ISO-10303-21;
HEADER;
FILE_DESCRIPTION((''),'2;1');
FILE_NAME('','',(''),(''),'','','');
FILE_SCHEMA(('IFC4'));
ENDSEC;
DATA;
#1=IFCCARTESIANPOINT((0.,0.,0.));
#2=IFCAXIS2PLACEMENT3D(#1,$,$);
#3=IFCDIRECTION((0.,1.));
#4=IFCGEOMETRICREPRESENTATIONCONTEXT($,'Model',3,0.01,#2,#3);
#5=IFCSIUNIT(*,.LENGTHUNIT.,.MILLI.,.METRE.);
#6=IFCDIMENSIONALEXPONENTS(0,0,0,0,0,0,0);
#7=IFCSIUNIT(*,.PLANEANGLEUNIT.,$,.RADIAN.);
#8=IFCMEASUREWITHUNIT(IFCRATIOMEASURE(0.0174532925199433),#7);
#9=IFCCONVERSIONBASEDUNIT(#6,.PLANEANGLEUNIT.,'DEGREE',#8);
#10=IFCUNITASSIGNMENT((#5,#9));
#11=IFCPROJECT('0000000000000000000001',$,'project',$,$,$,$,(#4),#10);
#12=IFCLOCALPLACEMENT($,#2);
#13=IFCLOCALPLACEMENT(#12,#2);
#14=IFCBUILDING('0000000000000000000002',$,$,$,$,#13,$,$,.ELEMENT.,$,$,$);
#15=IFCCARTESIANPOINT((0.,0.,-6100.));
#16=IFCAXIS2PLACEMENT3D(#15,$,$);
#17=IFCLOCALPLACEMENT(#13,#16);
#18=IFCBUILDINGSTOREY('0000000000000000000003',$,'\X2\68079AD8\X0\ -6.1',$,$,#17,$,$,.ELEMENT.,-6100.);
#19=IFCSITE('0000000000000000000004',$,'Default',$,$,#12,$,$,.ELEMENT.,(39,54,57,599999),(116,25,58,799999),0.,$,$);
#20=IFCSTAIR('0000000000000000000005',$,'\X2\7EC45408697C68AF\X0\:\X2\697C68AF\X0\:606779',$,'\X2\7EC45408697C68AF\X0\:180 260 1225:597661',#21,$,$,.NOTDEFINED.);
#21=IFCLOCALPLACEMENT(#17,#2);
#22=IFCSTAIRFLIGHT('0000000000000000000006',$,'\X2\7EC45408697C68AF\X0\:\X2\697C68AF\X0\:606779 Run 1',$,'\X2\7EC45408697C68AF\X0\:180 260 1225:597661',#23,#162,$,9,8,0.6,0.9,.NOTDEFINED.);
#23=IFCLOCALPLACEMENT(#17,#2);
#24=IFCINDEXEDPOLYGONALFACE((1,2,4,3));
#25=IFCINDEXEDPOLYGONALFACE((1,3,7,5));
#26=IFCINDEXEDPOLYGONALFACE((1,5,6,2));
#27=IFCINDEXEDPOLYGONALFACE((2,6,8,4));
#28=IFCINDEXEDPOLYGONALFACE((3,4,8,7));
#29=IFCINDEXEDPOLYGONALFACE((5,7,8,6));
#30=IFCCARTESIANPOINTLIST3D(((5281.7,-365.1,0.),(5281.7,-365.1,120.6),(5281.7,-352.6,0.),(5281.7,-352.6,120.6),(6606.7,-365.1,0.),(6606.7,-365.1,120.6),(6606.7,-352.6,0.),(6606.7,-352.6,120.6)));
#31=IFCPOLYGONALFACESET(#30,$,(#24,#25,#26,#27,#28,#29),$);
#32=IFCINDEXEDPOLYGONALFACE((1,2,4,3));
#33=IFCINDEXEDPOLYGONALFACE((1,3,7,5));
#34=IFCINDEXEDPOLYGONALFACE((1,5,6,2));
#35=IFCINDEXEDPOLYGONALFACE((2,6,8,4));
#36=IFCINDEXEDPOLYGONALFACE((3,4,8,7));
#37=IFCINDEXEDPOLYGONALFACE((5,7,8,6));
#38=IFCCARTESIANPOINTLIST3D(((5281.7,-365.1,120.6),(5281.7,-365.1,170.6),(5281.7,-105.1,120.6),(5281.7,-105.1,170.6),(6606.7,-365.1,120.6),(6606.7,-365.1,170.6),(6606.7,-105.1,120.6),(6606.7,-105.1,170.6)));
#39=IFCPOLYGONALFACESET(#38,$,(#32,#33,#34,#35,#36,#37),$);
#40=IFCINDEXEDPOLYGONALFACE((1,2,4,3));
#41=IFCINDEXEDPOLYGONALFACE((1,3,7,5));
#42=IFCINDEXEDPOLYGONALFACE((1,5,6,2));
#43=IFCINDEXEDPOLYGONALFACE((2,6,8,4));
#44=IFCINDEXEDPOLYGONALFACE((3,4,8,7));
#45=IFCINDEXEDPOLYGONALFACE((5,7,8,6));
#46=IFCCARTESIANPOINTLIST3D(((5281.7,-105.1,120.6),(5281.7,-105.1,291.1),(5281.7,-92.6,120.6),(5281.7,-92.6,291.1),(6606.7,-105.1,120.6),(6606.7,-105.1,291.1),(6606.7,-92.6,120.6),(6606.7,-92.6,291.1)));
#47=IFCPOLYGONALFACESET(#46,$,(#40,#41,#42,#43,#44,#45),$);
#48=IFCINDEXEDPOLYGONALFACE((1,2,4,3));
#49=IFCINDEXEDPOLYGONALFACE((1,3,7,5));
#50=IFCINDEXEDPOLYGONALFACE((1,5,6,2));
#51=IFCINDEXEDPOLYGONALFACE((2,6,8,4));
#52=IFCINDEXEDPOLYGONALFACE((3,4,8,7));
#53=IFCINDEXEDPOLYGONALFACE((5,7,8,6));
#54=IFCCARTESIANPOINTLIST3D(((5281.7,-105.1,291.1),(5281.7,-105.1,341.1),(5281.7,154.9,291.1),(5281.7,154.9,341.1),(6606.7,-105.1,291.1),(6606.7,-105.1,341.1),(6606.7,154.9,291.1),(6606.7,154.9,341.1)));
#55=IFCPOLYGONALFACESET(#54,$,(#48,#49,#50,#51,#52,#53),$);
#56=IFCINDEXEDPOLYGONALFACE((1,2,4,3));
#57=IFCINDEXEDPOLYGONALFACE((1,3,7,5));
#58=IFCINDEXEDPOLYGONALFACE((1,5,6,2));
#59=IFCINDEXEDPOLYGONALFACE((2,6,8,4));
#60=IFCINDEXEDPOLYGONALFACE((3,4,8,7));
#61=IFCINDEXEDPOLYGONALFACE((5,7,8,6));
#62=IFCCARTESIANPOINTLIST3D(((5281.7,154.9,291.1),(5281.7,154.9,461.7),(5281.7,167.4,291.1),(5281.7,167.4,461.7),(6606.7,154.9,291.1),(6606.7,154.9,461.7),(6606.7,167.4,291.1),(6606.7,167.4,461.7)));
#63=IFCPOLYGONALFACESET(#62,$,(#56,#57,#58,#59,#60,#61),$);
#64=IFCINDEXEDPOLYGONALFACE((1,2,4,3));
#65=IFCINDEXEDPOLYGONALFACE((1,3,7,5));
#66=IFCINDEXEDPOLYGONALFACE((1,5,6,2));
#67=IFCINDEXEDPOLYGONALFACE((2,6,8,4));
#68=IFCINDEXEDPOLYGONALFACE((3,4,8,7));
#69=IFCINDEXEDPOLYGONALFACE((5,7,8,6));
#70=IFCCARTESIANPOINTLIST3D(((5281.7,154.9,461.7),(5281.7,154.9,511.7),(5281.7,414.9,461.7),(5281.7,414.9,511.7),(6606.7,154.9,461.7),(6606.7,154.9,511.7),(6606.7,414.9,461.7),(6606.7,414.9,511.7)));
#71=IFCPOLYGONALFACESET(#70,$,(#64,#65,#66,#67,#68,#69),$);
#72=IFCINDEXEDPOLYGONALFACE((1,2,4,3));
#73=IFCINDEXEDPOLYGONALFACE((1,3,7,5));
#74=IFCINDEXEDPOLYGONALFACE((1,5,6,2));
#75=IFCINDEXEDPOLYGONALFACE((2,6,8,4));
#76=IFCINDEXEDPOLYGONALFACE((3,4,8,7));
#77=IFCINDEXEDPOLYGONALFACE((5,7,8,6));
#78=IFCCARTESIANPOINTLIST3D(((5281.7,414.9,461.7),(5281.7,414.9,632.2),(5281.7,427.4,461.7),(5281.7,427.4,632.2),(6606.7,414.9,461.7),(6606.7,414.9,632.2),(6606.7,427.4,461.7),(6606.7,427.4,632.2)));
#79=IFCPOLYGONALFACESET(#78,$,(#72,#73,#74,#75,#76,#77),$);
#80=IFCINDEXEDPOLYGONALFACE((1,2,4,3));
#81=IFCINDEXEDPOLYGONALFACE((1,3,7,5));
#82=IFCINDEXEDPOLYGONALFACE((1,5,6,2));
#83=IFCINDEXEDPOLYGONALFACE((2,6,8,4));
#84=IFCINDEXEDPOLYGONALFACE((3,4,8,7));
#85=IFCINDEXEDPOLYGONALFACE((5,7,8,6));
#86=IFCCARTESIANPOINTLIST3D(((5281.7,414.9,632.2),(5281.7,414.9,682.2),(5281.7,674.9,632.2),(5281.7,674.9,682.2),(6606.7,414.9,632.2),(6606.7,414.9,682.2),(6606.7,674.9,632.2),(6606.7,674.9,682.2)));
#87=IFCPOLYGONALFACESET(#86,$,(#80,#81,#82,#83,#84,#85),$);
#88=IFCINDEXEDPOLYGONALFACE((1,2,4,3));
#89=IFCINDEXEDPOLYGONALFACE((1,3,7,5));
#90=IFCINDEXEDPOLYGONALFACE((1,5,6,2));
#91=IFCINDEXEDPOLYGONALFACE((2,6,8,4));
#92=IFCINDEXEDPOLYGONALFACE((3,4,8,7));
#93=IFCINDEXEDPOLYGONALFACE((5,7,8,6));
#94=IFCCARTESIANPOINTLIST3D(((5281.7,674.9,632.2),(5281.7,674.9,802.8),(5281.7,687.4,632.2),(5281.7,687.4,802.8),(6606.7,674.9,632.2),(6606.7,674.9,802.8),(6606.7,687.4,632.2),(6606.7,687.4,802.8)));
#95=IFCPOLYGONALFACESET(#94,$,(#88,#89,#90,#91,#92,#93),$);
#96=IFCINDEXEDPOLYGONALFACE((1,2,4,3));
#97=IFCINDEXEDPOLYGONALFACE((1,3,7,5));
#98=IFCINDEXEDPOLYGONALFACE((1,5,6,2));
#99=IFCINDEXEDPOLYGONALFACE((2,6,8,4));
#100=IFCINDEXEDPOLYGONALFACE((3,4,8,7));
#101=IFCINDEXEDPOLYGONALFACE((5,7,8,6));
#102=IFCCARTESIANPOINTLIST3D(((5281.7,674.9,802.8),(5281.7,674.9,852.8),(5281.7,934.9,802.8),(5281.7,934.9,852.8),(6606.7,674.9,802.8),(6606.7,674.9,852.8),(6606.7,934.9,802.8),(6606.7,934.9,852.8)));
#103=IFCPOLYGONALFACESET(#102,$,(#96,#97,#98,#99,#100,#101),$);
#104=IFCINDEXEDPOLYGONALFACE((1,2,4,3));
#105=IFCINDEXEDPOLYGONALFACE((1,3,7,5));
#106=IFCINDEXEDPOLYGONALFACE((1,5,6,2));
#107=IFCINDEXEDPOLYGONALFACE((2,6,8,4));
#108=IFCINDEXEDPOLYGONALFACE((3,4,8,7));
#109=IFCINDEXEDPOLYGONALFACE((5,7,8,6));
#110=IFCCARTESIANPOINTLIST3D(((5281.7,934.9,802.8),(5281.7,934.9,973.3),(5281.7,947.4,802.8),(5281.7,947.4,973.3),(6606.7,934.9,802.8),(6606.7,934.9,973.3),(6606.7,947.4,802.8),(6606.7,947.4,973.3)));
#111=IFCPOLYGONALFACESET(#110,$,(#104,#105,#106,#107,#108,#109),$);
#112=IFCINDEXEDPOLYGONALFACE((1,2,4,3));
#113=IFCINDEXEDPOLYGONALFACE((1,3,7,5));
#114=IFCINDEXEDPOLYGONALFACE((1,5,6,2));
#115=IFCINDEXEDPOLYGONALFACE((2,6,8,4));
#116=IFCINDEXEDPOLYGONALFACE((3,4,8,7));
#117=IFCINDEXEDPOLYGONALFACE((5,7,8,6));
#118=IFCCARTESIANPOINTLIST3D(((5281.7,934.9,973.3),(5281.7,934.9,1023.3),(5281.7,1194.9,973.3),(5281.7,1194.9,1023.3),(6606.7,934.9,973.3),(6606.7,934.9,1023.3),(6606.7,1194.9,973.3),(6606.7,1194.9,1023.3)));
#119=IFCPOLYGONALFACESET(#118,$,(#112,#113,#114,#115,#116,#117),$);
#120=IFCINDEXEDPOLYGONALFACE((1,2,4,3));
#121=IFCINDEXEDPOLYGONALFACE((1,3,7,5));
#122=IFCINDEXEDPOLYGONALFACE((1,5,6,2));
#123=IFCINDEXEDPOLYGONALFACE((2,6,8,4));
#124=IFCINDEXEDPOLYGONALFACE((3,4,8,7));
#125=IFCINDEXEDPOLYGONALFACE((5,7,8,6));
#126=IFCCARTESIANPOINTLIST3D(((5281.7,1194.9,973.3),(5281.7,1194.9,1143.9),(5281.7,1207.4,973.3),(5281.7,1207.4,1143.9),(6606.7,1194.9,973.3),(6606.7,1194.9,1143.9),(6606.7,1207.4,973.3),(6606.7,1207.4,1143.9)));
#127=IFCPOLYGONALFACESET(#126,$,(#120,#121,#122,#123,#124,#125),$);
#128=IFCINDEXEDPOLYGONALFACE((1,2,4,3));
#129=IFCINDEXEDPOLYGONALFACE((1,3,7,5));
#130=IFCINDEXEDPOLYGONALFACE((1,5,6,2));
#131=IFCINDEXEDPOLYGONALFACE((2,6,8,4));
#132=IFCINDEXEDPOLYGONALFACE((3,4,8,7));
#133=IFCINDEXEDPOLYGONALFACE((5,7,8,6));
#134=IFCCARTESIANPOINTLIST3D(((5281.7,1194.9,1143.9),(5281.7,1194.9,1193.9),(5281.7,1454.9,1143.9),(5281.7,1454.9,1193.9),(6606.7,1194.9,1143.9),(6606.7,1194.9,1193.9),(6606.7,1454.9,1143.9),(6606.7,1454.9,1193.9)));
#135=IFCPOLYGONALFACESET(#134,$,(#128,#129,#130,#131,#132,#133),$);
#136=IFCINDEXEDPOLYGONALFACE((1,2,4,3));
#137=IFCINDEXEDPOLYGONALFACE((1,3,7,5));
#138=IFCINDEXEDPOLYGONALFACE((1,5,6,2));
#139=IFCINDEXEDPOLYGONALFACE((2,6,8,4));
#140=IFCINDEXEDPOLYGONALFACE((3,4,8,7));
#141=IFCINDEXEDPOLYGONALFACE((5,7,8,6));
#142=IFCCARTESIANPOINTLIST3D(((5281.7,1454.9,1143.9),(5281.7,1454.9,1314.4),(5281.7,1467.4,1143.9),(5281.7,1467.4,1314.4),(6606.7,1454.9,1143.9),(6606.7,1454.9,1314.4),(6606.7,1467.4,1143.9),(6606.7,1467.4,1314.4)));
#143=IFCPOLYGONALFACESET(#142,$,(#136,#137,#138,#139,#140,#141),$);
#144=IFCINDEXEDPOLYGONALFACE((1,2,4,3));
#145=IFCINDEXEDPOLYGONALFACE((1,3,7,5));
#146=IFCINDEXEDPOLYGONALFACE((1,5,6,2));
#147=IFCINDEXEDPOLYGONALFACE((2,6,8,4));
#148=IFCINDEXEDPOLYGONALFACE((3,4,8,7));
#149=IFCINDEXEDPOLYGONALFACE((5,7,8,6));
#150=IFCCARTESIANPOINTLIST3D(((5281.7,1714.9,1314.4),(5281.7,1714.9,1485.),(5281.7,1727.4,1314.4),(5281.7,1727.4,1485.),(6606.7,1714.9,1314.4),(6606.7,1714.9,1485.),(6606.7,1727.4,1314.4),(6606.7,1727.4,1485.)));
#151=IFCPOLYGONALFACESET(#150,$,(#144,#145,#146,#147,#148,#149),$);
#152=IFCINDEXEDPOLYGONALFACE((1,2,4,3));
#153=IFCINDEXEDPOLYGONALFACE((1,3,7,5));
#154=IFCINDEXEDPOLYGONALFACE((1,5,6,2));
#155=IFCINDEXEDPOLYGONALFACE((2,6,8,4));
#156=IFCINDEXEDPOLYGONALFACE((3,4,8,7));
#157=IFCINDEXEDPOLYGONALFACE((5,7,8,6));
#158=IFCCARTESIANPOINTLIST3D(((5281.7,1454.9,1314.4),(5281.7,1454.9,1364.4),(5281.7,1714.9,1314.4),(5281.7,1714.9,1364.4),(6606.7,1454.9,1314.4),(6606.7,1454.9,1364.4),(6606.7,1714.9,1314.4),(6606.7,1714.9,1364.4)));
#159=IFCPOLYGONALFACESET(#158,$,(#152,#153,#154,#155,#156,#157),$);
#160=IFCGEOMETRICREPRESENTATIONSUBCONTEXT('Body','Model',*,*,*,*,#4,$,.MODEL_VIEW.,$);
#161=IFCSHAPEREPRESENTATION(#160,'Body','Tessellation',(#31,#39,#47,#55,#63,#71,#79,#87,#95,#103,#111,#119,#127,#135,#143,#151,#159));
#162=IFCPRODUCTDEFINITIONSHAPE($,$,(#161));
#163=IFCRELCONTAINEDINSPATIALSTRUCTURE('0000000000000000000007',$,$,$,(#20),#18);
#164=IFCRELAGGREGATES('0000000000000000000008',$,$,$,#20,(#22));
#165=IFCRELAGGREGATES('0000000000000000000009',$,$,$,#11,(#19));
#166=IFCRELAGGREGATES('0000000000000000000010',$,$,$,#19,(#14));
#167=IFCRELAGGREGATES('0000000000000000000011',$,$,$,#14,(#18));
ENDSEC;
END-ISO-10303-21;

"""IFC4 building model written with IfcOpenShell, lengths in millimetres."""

from ifc_helpers import new_model, entity, si_unit, converted_unit, direction, frame, frame_2d, origin, origin_2d_with_axis, place, context, subcontext, project, spatial, rectangle, extrude, element, aggregate, save


model = new_model("IFC4")

# Units and contexts
model_context = context("Model", 3, precision=0.01, world=origin(), true_north=direction((0.0, 1.0)))
body_context = subcontext(model_context, "Body", "Model", "MODEL_VIEW")
ifc_project = project(units=[si_unit("LENGTHUNIT", "METRE", prefix="MILLI"), converted_unit("PLANEANGLEUNIT", "DEGREE", entity("IfcRatioMeasure", 0.0174532925199433), si_unit("PLANEANGLEUNIT", "RADIAN"), dimensions=[0, 0, 0, 0, 0, 0, 0])], contexts=[model_context])

# Site, building, storey
site_placement = place(None, origin())
site = spatial("IfcSite", under=ifc_project, at=site_placement, Name="Default", CompositionType="ELEMENT", RefLatitude=(39, 54, 57, 599999), RefLongitude=(116, 25, 58, 799999), RefElevation=0.0)
building_placement = place(site_placement, origin())
building = spatial("IfcBuilding", under=site, at=building_placement, CompositionType="ELEMENT")
storey_placement = place(building_placement, frame((0.0, 0.0, -6100.0)))
storey = spatial("IfcBuildingStorey", under=building, at=storey_placement, Name="标高 -6.1", CompositionType="ELEMENT", Elevation=-6100.0)

# Stair
stair_placement = place(storey_placement, origin())
stair = element("IfcStair", 1, at=stair_placement, inside=storey, Name="组合楼梯:楼梯:606779", ObjectType="组合楼梯:180 260 1225:597661", PredefinedType="NOTDEFINED")

# Stair flight
stair_flight_1_placement = place(stair_placement, frame((5281.7, -365.1, 0.0)))
stair_flight_1 = element("IfcStairFlight", 2, at=stair_flight_1_placement, Name="组合楼梯:楼梯:606779 Run 1", ObjectType="组合楼梯:180 260 1225:597661", NumberOfRisers=9, NumberOfTreads=8, PredefinedType="NOTDEFINED", RiserHeight=0.6, TreadLength=0.9, context=body_context, shape_type="SweptSolid", body=[
    extrude(rectangle(XDim=1325.0, YDim=12.5, at=origin_2d_with_axis()), frame((662.5, 6.2, 0.0), z_axis=(0.0, 0.0, 1.0), x_axis=(-1.0, 0.0, 0.0)), (0.0, 0.0, 1.0), 120.6),
    extrude(rectangle(XDim=260.0, YDim=1325.0, at=frame_2d((0.0, 0.0), x_axis=(1.0, 0.0))), frame((662.5, 130.0, 120.6), z_axis=(0.0, 0.0, 1.0), x_axis=(0.0, -1.0, 0.0)), (0.0, 0.0, 1.0), 50.0),
    extrude(rectangle(XDim=1325.0, YDim=12.5, at=origin_2d_with_axis()), frame((662.5, 266.2, 120.6), z_axis=(0.0, 0.0, 1.0), x_axis=(-1.0, 0.0, 0.0)), (0.0, 0.0, 1.0), 170.6),
    extrude(rectangle(XDim=260.0, YDim=1325.0, at=frame_2d((0.0, 0.0), x_axis=(1.0, 0.0))), frame((662.5, 390.0, 291.1), z_axis=(0.0, 0.0, 1.0), x_axis=(0.0, -1.0, 0.0)), (0.0, 0.0, 1.0), 50.0),
    extrude(rectangle(XDim=1325.0, YDim=12.5, at=frame_2d((0.0, 0.0), x_axis=(1.0, 0.0))), frame((662.5, 526.2, 291.1), z_axis=(0.0, 0.0, 1.0), x_axis=(-1.0, 0.0, 0.0)), (0.0, 0.0, 1.0), 170.6),
    extrude(rectangle(XDim=260.0, YDim=1325.0, at=frame_2d((0.0, 0.0), x_axis=(1.0, 0.0))), frame((662.5, 650.0, 461.7), z_axis=(0.0, 0.0, 1.0), x_axis=(0.0, -1.0, 0.0)), (0.0, 0.0, 1.0), 50.0),
    extrude(rectangle(XDim=1325.0, YDim=12.5, at=origin_2d_with_axis()), frame((662.5, 786.3, 461.7), z_axis=(0.0, 0.0, 1.0), x_axis=(-1.0, 0.0, 0.0)), (0.0, 0.0, 1.0), 170.6),
    extrude(rectangle(XDim=260.0, YDim=1325.0, at=frame_2d((0.0, 0.0), x_axis=(1.0, 0.0))), frame((662.5, 910.0, 632.2), z_axis=(0.0, 0.0, 1.0), x_axis=(0.0, -1.0, 0.0)), (0.0, 0.0, 1.0), 50.0),
    extrude(rectangle(XDim=1325.0, YDim=12.5, at=origin_2d_with_axis()), frame((662.5, 1046.2, 632.2), z_axis=(0.0, 0.0, 1.0), x_axis=(-1.0, 0.0, 0.0)), (0.0, 0.0, 1.0), 170.6),
    extrude(rectangle(XDim=260.0, YDim=1325.0, at=frame_2d((0.0, 0.0), x_axis=(1.0, 0.0))), frame((662.5, 1170.0, 802.8), z_axis=(0.0, 0.0, 1.0), x_axis=(0.0, -1.0, 0.0)), (0.0, 0.0, 1.0), 50.0),
    extrude(rectangle(XDim=1325.0, YDim=12.5, at=origin_2d_with_axis()), frame((662.5, 1306.2, 802.8), z_axis=(0.0, 0.0, 1.0), x_axis=(-1.0, 0.0, 0.0)), (0.0, 0.0, 1.0), 170.6),
    extrude(rectangle(XDim=260.0, YDim=1325.0, at=frame_2d((0.0, 0.0), x_axis=(1.0, 0.0))), frame((662.5, 1430.0, 973.3), z_axis=(0.0, 0.0, 1.0), x_axis=(0.0, -1.0, 0.0)), (0.0, 0.0, 1.0), 50.0),
    extrude(rectangle(XDim=1325.0, YDim=12.5, at=origin_2d_with_axis()), frame((662.5, 1566.2, 973.3), z_axis=(0.0, 0.0, 1.0), x_axis=(-1.0, 0.0, 0.0)), (0.0, 0.0, 1.0), 170.6),
    extrude(rectangle(XDim=260.0, YDim=1325.0, at=frame_2d((0.0, 0.0), x_axis=(1.0, 0.0))), frame((662.5, 1690.0, 1143.9), z_axis=(0.0, 0.0, 1.0), x_axis=(0.0, -1.0, 0.0)), (0.0, 0.0, 1.0), 50.0),
    extrude(rectangle(XDim=1325.0, YDim=12.5, at=frame_2d((0.0, 0.0), x_axis=(1.0, 0.0))), frame((662.5, 1826.2, 1143.9), z_axis=(0.0, 0.0, 1.0), x_axis=(-1.0, 0.0, 0.0)), (0.0, 0.0, 1.0), 170.6),
    extrude(rectangle(XDim=1325.0, YDim=12.5, at=frame_2d((0.0, 0.0), x_axis=(1.0, 0.0))), frame((662.5, 2086.2, 1314.4), z_axis=(0.0, 0.0, 1.0), x_axis=(-1.0, 0.0, 0.0)), (0.0, 0.0, 1.0), 170.6),
    extrude(rectangle(XDim=260.0, YDim=1325.0, at=frame_2d((0.0, 0.0), x_axis=(1.0, 0.0))), frame((662.5, 1950.0, 1314.4), z_axis=(0.0, 0.0, 1.0), x_axis=(0.0, -1.0, 0.0)), (0.0, 0.0, 1.0), 50.0),
])

aggregate(stair, [stair_flight_1])

save(model, "model.ifc")
